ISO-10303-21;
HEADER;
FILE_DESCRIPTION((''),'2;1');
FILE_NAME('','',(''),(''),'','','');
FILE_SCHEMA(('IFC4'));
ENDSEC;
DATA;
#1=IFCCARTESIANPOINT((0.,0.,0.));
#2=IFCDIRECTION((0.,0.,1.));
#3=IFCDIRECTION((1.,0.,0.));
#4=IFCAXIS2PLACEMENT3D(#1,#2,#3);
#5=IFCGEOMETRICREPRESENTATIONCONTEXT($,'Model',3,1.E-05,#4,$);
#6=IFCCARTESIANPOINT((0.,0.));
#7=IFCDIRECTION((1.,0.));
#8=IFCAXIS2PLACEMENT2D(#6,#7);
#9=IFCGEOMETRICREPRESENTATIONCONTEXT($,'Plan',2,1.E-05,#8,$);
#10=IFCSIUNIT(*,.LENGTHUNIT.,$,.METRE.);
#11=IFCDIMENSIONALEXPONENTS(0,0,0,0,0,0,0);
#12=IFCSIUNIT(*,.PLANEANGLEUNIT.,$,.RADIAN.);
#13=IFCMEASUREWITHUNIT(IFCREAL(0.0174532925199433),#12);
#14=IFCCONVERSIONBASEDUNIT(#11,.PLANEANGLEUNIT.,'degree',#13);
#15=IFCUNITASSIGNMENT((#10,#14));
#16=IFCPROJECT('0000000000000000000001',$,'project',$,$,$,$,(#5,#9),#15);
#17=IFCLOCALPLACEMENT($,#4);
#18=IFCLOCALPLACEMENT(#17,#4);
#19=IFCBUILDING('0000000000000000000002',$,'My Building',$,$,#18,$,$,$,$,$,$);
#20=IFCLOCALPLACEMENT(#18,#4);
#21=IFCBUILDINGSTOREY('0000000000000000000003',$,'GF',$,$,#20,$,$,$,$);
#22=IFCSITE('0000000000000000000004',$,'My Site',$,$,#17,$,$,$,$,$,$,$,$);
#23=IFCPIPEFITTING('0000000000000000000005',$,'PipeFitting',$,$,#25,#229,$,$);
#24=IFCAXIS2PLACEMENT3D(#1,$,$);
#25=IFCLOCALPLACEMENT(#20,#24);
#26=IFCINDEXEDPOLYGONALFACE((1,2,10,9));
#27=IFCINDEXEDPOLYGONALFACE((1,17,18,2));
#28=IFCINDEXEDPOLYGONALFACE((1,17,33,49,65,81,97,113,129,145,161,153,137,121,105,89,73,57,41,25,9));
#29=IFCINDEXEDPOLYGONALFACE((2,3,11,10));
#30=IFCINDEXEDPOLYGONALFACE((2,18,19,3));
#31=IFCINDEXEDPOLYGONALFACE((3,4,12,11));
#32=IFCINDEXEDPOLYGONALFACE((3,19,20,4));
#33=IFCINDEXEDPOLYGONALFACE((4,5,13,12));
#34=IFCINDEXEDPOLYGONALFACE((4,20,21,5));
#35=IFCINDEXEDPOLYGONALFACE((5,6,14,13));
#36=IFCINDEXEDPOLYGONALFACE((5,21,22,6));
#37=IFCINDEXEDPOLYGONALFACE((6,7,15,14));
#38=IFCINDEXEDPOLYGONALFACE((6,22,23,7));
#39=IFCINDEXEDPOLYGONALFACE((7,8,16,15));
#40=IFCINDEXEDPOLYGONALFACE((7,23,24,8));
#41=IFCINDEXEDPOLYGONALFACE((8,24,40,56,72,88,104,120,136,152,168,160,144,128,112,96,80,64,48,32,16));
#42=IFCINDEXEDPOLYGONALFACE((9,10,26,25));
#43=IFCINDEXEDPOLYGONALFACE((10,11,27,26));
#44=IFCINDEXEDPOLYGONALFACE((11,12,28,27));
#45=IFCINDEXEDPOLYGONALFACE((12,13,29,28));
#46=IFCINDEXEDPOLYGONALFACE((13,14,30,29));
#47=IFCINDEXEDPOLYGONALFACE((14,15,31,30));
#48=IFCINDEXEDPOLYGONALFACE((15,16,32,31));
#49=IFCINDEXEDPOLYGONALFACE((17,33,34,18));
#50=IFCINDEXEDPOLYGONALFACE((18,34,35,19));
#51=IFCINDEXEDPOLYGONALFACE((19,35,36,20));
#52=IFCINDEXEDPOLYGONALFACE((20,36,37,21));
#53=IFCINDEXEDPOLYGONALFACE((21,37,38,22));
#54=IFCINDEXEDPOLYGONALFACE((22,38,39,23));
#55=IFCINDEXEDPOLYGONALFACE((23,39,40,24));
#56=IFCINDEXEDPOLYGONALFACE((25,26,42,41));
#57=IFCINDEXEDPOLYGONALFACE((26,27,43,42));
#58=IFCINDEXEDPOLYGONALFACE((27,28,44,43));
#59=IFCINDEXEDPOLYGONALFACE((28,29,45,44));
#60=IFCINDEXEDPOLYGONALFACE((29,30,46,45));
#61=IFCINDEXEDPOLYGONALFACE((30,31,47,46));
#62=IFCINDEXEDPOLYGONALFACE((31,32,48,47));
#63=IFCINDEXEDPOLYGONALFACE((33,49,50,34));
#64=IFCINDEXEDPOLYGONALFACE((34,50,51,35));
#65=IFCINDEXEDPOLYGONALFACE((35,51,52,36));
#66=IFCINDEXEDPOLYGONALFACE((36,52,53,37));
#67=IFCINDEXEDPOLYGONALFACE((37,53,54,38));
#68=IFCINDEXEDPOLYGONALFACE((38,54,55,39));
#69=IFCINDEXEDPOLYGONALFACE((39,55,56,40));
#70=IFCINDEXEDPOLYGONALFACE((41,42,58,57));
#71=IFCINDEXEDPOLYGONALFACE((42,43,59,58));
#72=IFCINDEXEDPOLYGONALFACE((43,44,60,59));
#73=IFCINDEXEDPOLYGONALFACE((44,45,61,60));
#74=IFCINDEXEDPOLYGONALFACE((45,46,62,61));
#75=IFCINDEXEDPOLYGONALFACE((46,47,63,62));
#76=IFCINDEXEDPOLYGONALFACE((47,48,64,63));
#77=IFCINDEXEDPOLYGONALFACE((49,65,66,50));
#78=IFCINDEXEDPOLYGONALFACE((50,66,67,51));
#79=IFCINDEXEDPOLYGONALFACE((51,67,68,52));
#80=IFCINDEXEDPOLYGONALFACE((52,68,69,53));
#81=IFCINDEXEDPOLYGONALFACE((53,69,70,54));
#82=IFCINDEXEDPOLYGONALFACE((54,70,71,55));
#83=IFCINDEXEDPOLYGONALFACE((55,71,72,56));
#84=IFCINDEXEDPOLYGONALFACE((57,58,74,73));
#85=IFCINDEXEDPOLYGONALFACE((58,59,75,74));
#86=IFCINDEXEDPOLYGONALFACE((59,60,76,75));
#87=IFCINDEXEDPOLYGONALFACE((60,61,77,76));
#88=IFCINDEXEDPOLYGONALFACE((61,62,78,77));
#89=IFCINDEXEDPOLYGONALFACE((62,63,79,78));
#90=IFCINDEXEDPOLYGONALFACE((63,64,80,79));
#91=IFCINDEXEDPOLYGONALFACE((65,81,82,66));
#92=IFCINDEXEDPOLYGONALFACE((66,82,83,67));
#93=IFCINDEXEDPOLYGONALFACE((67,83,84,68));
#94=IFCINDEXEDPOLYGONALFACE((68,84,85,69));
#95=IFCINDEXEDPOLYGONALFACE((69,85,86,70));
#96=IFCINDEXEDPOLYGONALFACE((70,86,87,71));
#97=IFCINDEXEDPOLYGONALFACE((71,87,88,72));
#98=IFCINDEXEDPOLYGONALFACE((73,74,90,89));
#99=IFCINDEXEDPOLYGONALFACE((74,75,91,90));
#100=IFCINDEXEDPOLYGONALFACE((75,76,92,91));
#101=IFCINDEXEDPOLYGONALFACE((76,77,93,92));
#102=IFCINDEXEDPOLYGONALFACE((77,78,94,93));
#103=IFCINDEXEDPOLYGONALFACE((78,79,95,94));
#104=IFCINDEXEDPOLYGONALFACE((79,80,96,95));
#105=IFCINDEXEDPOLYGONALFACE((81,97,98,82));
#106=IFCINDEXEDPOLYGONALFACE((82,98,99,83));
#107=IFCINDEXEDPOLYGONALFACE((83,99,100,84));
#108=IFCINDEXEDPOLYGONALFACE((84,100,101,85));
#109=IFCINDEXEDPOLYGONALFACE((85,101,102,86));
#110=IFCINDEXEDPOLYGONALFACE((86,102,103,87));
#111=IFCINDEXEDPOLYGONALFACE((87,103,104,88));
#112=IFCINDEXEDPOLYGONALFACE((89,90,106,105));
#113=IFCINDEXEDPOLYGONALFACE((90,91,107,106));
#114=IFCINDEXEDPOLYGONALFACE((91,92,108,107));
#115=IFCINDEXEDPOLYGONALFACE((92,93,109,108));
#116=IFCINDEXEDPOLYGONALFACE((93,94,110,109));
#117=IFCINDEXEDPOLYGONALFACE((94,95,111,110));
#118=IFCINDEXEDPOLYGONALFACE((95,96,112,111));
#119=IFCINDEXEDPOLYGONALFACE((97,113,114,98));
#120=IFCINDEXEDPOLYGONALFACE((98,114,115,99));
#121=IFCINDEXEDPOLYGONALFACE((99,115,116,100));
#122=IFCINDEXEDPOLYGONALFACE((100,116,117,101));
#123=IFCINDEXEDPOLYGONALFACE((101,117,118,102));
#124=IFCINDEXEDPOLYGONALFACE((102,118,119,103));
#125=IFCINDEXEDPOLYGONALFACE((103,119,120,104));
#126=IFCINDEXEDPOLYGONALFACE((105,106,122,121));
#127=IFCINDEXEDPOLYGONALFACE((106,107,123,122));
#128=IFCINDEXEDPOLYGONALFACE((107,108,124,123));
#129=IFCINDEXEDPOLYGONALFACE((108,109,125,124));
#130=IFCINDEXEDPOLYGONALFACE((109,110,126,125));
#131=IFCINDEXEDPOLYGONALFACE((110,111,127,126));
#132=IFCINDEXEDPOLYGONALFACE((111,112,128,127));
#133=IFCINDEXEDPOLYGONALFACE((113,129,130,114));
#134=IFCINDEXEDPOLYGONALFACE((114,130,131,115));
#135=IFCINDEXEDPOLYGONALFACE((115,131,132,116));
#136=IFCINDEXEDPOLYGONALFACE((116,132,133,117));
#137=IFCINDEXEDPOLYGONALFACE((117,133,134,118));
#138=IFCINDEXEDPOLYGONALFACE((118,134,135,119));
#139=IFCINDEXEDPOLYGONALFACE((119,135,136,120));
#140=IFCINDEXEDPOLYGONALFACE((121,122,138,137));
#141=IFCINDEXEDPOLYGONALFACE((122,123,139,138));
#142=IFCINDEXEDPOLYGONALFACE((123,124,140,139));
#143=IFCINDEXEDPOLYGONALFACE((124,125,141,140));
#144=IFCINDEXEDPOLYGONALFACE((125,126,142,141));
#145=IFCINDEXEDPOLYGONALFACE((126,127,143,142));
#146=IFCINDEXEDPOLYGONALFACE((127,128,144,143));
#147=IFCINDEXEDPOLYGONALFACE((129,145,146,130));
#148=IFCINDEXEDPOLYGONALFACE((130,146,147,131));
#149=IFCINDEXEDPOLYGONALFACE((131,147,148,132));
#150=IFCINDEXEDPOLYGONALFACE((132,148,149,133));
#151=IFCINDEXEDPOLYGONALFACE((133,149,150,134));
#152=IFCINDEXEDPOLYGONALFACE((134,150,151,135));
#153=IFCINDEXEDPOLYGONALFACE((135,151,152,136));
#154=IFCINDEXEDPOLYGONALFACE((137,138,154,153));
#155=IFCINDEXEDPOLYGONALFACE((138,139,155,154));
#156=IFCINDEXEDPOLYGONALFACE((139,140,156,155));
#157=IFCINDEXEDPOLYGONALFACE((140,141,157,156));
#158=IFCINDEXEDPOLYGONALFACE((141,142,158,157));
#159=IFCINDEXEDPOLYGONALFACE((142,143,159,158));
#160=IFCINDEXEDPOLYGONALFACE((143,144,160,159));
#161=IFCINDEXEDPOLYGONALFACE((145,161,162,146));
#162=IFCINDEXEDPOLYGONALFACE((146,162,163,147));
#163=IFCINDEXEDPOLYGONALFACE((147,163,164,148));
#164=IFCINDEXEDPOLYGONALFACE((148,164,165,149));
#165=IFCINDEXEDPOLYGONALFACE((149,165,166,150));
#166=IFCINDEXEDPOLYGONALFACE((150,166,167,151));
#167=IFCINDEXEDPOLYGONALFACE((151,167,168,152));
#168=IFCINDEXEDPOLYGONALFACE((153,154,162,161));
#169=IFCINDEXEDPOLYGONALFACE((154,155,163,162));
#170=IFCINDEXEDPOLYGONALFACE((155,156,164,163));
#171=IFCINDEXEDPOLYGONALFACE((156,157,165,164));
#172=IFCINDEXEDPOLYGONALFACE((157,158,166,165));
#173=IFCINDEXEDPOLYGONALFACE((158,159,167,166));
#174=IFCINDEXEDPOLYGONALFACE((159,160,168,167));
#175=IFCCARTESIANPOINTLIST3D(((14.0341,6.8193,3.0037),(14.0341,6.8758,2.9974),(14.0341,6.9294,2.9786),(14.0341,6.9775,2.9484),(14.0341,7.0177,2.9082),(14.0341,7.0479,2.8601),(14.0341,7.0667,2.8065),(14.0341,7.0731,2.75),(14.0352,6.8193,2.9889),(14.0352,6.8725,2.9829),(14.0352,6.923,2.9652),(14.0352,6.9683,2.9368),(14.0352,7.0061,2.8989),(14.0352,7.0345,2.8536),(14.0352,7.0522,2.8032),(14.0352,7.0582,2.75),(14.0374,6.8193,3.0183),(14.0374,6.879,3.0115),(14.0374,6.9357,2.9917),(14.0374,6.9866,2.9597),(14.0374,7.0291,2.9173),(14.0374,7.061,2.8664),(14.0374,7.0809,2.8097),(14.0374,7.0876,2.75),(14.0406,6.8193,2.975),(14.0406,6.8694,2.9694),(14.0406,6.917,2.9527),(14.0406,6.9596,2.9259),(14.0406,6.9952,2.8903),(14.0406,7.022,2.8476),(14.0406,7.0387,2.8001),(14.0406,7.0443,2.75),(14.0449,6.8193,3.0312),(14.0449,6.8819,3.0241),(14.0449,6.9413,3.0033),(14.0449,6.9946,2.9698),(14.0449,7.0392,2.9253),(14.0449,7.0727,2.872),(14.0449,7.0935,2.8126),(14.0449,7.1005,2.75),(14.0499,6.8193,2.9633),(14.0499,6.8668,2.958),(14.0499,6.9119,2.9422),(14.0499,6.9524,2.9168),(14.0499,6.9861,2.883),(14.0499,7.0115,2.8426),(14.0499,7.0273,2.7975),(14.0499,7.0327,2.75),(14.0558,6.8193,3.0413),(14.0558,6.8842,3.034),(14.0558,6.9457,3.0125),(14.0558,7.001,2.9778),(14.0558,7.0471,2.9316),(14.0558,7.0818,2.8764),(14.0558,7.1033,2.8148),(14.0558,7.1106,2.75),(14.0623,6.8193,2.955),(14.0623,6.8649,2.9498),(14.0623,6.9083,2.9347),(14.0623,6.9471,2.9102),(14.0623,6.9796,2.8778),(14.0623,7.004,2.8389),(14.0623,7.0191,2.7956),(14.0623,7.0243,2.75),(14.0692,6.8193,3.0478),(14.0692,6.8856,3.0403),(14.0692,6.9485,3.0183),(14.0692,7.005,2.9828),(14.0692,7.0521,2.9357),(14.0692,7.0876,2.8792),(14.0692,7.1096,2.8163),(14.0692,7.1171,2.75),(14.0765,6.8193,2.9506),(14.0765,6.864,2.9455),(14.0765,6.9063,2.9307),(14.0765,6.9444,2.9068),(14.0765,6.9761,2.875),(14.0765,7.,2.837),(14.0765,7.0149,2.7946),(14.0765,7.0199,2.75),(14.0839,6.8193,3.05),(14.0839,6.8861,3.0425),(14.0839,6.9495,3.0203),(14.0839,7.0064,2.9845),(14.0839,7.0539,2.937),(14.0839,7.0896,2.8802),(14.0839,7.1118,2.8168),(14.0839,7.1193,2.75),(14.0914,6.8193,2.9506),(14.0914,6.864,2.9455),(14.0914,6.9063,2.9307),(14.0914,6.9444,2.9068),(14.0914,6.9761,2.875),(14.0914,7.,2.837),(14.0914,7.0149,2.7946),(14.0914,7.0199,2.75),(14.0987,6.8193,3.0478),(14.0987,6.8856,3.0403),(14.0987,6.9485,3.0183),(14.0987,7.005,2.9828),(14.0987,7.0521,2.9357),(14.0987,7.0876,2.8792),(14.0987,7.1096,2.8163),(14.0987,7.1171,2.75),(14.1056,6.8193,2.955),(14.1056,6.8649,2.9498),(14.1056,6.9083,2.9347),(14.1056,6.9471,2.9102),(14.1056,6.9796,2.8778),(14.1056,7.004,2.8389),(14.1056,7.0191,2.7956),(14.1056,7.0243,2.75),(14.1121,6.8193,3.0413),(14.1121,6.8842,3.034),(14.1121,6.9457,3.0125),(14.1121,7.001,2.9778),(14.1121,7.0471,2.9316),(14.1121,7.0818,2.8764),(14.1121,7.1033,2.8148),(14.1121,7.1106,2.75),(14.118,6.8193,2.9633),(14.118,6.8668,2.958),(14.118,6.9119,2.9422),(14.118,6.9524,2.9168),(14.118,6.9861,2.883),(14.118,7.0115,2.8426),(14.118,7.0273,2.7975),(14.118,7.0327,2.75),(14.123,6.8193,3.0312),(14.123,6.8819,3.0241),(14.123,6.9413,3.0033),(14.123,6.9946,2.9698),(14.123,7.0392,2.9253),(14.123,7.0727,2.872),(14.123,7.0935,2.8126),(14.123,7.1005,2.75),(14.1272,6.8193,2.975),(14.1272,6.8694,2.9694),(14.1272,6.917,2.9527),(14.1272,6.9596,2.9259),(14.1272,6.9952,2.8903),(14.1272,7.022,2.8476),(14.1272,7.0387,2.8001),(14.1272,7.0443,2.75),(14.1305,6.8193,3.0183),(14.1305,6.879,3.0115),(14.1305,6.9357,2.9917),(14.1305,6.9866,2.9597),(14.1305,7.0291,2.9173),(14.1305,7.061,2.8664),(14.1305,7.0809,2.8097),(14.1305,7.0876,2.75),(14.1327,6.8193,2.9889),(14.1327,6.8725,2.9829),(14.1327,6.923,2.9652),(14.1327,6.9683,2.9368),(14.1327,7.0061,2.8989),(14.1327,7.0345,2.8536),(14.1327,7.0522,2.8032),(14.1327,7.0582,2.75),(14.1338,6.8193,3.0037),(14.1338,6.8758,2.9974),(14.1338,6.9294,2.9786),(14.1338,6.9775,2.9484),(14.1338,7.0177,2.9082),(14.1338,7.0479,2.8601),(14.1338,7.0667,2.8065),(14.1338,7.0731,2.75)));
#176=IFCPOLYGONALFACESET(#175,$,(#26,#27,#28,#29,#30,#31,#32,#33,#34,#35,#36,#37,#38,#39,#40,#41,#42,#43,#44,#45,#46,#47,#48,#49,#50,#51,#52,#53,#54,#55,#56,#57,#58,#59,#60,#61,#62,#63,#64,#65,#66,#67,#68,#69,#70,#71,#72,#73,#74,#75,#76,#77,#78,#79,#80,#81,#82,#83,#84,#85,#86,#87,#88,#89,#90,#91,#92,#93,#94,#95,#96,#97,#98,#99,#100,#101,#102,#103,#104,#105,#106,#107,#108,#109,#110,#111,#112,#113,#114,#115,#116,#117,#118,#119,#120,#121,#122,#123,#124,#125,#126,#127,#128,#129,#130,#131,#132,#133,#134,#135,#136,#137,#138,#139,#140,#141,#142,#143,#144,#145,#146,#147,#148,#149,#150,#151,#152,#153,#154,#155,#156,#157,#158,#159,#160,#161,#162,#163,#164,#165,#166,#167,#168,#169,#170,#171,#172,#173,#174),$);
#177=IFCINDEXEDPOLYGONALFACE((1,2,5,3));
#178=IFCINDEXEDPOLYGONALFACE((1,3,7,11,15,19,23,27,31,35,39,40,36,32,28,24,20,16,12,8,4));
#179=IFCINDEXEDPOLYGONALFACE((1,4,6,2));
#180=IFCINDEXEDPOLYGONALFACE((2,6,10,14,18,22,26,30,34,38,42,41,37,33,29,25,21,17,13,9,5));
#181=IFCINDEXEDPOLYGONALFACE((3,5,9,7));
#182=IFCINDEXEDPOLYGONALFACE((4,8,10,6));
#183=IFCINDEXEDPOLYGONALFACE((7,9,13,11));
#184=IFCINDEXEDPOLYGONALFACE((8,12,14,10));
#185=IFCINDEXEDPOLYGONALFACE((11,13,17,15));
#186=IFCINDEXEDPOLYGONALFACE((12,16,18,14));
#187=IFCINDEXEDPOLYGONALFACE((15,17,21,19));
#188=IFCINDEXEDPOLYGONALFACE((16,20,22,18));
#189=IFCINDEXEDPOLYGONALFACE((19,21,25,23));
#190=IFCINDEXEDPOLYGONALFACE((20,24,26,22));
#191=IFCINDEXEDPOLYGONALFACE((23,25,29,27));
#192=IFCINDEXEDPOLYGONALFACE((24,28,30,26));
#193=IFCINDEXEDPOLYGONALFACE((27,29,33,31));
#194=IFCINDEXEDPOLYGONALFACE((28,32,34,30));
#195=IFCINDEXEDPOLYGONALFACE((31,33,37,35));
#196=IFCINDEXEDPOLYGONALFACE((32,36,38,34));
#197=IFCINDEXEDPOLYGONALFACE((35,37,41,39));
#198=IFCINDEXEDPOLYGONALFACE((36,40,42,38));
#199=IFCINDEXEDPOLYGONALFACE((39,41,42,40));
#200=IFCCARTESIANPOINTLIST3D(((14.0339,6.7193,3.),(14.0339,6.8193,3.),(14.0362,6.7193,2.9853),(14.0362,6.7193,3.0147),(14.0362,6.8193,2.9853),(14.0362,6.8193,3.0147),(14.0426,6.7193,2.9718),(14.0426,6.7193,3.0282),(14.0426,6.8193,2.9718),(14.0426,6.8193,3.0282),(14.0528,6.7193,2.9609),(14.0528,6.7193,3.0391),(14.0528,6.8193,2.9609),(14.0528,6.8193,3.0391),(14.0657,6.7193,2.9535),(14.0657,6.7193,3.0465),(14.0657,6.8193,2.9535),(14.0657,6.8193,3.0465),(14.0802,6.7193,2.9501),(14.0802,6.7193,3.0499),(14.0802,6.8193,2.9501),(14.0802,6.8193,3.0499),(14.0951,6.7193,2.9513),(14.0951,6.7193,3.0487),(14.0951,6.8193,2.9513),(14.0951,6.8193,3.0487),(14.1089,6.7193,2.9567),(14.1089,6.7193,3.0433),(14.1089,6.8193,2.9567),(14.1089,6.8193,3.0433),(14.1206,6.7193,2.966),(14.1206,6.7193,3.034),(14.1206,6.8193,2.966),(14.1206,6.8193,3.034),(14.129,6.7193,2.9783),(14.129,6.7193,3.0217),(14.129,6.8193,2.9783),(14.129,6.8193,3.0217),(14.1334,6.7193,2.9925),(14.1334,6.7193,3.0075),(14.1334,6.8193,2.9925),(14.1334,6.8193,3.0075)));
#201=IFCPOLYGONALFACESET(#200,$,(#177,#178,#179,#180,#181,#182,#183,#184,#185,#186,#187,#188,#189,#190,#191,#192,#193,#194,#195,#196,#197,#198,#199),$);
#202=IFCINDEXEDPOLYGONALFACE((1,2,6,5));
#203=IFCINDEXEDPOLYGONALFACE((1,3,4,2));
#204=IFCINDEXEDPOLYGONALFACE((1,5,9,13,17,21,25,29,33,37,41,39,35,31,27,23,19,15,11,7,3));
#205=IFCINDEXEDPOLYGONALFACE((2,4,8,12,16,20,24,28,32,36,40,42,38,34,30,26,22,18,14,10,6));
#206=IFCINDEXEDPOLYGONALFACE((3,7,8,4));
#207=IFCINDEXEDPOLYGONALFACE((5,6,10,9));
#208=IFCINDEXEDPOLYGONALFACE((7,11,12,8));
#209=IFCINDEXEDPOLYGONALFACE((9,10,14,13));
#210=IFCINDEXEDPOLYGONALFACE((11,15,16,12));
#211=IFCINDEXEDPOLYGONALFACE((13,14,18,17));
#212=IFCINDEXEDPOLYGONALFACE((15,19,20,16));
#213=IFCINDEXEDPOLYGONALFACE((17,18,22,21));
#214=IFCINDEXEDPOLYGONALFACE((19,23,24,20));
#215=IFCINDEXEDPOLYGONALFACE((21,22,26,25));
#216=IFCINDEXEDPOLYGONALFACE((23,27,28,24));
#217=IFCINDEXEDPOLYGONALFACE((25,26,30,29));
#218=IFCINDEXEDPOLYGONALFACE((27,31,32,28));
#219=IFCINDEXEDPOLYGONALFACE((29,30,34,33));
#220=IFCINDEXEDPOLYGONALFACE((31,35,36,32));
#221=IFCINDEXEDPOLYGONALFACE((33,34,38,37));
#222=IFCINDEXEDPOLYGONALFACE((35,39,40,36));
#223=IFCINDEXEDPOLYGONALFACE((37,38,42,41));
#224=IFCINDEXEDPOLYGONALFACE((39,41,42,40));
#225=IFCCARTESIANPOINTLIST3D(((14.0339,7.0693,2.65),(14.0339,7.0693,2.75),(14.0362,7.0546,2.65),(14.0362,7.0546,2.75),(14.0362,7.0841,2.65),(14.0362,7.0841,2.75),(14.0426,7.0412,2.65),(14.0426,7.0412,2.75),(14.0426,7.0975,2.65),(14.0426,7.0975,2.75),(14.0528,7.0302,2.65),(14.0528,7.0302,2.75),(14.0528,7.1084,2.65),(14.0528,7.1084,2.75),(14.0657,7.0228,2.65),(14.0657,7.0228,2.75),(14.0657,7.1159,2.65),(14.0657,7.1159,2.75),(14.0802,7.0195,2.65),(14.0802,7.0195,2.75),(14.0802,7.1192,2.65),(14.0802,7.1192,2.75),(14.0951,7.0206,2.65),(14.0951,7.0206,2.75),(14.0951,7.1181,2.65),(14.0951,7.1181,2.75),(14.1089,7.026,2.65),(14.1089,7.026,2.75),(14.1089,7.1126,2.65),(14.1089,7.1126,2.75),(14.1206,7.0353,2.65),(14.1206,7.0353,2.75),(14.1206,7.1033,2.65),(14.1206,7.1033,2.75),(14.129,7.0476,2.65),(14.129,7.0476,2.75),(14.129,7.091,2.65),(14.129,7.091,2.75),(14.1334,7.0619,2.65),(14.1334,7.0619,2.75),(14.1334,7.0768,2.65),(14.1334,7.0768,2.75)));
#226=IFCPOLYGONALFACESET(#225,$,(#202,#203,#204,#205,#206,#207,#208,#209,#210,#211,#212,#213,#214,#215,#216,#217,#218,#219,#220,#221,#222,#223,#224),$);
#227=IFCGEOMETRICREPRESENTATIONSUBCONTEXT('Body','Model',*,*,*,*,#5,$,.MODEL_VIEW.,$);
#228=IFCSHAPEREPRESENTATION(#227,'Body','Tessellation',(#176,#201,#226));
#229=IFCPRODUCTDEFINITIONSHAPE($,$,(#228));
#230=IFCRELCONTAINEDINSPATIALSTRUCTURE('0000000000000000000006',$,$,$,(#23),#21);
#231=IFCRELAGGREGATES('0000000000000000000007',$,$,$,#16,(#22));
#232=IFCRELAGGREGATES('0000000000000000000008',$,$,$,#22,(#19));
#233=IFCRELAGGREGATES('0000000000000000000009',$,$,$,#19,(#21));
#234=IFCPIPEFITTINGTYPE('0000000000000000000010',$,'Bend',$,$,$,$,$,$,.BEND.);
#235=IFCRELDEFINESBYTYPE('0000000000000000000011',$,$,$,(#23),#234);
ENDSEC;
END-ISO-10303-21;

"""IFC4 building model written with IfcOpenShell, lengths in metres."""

from ifc_helpers import new_model, entity, si_unit, converted_unit, frame, origin_with_axes, origin_2d_with_axis, place, context, subcontext, project, spatial, circle, extrude, source, transform, mapped, type_object, type_shapes, element, save


model = new_model("IFC4")

# Units and contexts
model_context = context("Model", 3, precision=1e-05, world=origin_with_axes())
plan_context = context("Plan", 2, precision=1e-05, world=origin_2d_with_axis())
body_context = subcontext(model_context, "Body", "Model", "MODEL_VIEW")
ifc_project = project(units=[si_unit("LENGTHUNIT", "METRE"), converted_unit("PLANEANGLEUNIT", "degree", entity("IfcReal", 0.0174532925199433), si_unit("PLANEANGLEUNIT", "RADIAN"), dimensions=[0, 0, 0, 0, 0, 0, 0])], contexts=[model_context, plan_context])

# Site, building, storey
site_placement = place(None, origin_with_axes())
site = spatial("IfcSite", under=ifc_project, at=site_placement, Name="My Site")
building_placement = place(site_placement, origin_with_axes())
building = spatial("IfcBuilding", under=site, at=building_placement, Name="My Building")
storey_placement = place(building_placement, origin_with_axes())
storey = spatial("IfcBuildingStorey", under=building, at=storey_placement, Name="GF")

# Pipe fitting
pipe_fitting_type = type_object("IfcPipeFittingType", Name="Bend", PredefinedType="BEND")
shared_shape = source(origin_with_axes(), body_context, "Body", "SolidModel", [
    entity("IfcSweptDiskSolid", entity("IfcIndexedPolyCurve", entity("IfcCartesianPointList3D", [[0.0, 0.0, 0.1], [0.0, -0.0732, 0.2768], [0.0, -0.25, 0.35]]), [entity("IfcArcIndex", [1, 2, 3])]), 0.05),
    extrude(circle(Radius=0.05), origin_with_axes(), (0.0, 0.0, 1.0), 0.1),
    extrude(circle(Radius=0.05), frame((0.0, -0.25, 0.35), z_axis=(0.0, -1.0, 0.0), x_axis=(1.0, 0.0, 0.0)), (0.0, 0.0, 1.0), 0.1),
])
type_shapes(pipe_fitting_type, [shared_shape])
for number, where, z_axis, x_axis, name in (
    (1, (14.0839, 6.7193, 3.0), (0.0, 1.0, 0.0), (-1.0, 0.0, 0.0), "PipeFitting"),
):
    element("IfcPipeFitting", number, at=place(storey_placement, frame(where, z_axis=z_axis, x_axis=x_axis)), inside=storey, type_object=pipe_fitting_type, Name=name, context=body_context, shape_type="MappedRepresentation", body=[
        mapped(shared_shape, transform((0.0, 0.0, 0.0), x_axis=(1.0, 0.0, 0.0), y_axis=(0.0, 1.0, 0.0), z_axis=(0.0, 0.0, 1.0), scale=1.0)),
    ])

save(model, "model.ifc")
